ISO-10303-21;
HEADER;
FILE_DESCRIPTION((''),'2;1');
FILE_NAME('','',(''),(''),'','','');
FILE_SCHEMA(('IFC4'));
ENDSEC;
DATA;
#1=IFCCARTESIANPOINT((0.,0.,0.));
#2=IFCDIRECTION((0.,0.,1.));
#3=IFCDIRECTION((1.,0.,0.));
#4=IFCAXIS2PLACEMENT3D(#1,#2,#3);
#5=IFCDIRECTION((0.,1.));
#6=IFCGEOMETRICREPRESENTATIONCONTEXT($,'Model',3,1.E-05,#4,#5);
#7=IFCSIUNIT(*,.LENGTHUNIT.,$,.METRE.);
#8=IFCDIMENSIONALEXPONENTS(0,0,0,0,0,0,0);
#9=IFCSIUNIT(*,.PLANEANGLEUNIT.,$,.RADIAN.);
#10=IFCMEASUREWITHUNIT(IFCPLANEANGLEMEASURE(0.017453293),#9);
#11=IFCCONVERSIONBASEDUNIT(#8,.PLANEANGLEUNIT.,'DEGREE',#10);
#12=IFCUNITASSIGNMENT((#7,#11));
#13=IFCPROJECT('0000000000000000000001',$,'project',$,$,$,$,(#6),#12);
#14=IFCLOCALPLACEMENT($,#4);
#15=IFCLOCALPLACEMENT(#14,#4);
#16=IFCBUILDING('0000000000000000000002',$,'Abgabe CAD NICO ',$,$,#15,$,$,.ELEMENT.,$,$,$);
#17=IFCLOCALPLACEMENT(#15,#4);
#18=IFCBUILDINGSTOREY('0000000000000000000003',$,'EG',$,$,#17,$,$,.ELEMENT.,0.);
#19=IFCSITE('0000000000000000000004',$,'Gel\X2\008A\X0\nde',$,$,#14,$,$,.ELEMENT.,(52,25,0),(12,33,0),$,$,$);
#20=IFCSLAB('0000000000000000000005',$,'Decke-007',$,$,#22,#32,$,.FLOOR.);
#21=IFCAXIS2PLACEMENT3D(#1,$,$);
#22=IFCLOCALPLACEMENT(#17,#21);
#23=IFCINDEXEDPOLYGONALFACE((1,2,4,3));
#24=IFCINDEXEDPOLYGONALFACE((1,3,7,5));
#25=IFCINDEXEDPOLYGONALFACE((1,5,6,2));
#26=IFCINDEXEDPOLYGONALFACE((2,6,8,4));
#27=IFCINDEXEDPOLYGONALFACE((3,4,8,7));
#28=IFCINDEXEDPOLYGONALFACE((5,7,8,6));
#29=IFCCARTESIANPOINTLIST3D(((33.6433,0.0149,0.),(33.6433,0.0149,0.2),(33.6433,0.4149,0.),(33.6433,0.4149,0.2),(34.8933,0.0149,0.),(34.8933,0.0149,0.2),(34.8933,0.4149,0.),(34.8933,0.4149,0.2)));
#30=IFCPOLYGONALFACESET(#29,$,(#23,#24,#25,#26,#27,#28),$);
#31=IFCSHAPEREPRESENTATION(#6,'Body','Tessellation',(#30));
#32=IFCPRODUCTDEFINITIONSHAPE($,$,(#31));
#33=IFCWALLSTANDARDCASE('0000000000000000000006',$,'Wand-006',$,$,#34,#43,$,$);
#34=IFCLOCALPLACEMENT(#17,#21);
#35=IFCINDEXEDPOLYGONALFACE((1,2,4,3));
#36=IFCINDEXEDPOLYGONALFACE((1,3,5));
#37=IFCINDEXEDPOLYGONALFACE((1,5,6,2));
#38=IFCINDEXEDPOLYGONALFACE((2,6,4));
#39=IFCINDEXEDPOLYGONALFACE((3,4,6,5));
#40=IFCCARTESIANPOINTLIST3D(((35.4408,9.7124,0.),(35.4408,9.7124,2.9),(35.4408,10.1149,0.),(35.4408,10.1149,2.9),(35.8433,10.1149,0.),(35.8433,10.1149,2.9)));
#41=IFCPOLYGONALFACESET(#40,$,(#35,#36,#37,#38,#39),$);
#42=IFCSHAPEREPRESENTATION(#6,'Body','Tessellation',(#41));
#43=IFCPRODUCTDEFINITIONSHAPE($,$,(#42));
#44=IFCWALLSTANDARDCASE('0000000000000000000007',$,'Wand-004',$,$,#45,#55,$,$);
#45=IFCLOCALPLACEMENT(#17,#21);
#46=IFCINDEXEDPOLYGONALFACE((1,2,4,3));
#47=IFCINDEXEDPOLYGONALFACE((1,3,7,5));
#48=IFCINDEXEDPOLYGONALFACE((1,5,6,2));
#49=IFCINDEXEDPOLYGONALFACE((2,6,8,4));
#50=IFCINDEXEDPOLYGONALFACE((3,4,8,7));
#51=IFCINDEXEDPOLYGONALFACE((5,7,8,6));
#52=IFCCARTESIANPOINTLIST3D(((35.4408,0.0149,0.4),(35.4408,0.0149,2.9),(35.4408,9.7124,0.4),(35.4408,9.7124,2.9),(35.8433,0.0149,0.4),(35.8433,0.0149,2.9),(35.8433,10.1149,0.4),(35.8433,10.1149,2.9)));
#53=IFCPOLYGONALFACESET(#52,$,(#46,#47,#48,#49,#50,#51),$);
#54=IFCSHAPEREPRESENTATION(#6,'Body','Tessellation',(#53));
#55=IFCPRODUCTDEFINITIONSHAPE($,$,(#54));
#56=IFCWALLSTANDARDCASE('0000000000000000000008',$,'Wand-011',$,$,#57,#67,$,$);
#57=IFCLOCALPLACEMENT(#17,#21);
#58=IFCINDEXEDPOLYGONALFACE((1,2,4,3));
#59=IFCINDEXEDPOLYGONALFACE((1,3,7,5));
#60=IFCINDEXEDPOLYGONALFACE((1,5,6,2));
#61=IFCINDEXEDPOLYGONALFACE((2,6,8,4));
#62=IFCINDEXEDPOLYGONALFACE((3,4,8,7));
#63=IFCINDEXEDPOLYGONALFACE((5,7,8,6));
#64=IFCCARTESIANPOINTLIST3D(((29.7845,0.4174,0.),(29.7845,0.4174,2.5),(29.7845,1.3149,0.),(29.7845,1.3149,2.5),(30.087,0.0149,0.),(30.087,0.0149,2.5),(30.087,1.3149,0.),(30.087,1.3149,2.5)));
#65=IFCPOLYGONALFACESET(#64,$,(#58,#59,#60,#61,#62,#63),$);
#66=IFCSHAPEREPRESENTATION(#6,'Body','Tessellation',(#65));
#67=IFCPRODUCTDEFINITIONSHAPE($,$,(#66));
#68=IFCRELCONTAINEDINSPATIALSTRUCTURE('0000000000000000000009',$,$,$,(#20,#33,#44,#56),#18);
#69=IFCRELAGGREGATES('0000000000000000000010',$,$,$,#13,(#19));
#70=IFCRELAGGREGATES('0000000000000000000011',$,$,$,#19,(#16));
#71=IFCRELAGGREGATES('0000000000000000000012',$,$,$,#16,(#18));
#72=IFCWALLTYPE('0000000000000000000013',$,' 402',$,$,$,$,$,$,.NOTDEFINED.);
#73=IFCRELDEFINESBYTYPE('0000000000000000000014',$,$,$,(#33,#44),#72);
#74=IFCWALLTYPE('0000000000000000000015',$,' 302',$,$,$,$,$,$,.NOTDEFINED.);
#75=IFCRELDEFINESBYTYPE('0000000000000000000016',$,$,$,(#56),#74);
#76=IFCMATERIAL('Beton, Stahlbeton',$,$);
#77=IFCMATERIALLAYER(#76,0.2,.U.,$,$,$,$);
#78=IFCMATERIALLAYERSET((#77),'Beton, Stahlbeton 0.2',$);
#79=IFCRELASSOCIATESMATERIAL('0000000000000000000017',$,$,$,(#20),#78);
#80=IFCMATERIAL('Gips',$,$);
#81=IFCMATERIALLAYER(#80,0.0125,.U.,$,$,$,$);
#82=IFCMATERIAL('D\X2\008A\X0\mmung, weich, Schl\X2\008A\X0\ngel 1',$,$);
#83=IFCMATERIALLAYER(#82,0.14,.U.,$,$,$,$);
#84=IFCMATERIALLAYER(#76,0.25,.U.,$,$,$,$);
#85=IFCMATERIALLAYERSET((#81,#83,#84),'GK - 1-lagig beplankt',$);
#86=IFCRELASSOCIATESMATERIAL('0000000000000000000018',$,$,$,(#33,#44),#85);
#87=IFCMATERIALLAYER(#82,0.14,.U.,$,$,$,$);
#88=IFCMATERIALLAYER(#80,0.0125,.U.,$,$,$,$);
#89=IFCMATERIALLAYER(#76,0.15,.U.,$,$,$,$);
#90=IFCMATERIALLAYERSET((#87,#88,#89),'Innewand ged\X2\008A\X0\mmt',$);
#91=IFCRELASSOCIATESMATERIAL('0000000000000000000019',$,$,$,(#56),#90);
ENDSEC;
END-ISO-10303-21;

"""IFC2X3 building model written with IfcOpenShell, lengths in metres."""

from ifc_helpers import new_model, entity, si_unit, converted_unit, direction, frame, origin_with_axes, place, context, project, spatial, polyline, outline, extrude, material, layer, layer_set, layer_usage, type_object, element, save


model = new_model("IFC2X3")

# Units and contexts
model_context = context("Model", 3, precision=1e-05, world=origin_with_axes(), true_north=direction((0.0, 1.0)))
ifc_project = project(units=[si_unit("LENGTHUNIT", "METRE"), converted_unit("PLANEANGLEUNIT", "DEGREE", entity("IfcPlaneAngleMeasure", 0.017453293), si_unit("PLANEANGLEUNIT", "RADIAN"), dimensions=[0, 0, 0, 0, 0, 0, 0])], contexts=[model_context])

# Site, building, storey
site_placement = place(None, origin_with_axes())
site = spatial("IfcSite", under=ifc_project, at=site_placement, Name="Gel\u008ande", CompositionType="ELEMENT", RefLatitude=(52, 25, 0), RefLongitude=(12, 33, 0))
building_placement = place(site_placement, origin_with_axes())
building = spatial("IfcBuilding", under=site, at=building_placement, Name="Abgabe CAD NICO ", CompositionType="ELEMENT")
storey_placement = place(building_placement, origin_with_axes())
storey = spatial("IfcBuildingStorey", under=building, at=storey_placement, Name="EG", CompositionType="ELEMENT", Elevation=0.0)

# Slab
ifc_material_1 = material(Name="Beton, Stahlbeton")
ifc_layer_1 = layer(ifc_material_1, 0.2, ventilated="UNKNOWN")
ifc_layer_set_1 = layer_set([ifc_layer_1], Name="Beton, Stahlbeton 0.2")
ifc_layer_usage_1 = layer_usage(ifc_layer_set_1, "AXIS3", "NEGATIVE", 0.2)
slab_placement = place(storey_placement, frame((33.6433, 0.0149, 0.0), z_axis=(0.0, 0.0, 1.0), x_axis=(1.0, 0.0, 0.0)))
element("IfcSlab", 1, at=slab_placement, inside=storey, material=ifc_layer_usage_1, Name="Decke-007", PredefinedType="FLOOR", context=model_context, shape_type="SweptSolid", body=[
    extrude(outline(polyline([(0.0, 0.0), (1.25, 0.0), (1.25, 0.4), (0.0, 0.4), (0.0, 0.0)])), origin_with_axes(), (0.0, 0.0, 1.0), 0.2),
])

# Walls
ifc_material_2 = material(Name="Gips")
ifc_layer_2 = layer(ifc_material_2, 0.0125, ventilated="UNKNOWN")
ifc_material_3 = material(Name="D\u008ammung, weich, Schl\u008angel 1")
ifc_layer_3 = layer(ifc_material_3, 0.14, ventilated="UNKNOWN")
ifc_layer_4 = layer(ifc_material_1, 0.25, ventilated="UNKNOWN")
ifc_layer_set_2 = layer_set([ifc_layer_2, ifc_layer_3, ifc_layer_4], Name="GK - 1-lagig beplankt")
ifc_layer_usage_2 = layer_usage(ifc_layer_set_2, "AXIS2", "NEGATIVE", 0.0)
wall_type_1 = type_object("IfcWallType", Name=" 402", PredefinedType="NOTDEFINED")
wall_1_placement = place(storey_placement, frame((35.4408, 10.1149, 0.0), z_axis=(0.0, 0.0, 1.0), x_axis=(1.0, 0.0, 0.0)))
element("IfcWallStandardCase", 2, at=wall_1_placement, inside=storey, type_object=wall_type_1, material=ifc_layer_usage_2, Name="Wand-006", context=model_context, shape_type="SweptSolid", body=[
    extrude(outline(polyline([(0.0, -0.4025), (0.4025, 0.0), (0.0, 0.0), (0.0, -0.4025)])), origin_with_axes(), (0.0, 0.0, 1.0), 2.9),
])
ifc_layer_usage_3 = layer_usage(ifc_layer_set_2, "AXIS2", "NEGATIVE", 0.0)
wall_2_placement = place(storey_placement, frame((35.8433, 10.1149, 0.4), z_axis=(0.0, 0.0, 1.0), x_axis=(0.0, -1.0, 0.0)))
element("IfcWallStandardCase", 3, at=wall_2_placement, inside=storey, type_object=wall_type_1, material=ifc_layer_usage_3, Name="Wand-004", context=model_context, shape_type="SweptSolid", body=[
    extrude(outline(polyline([(0.4025, -0.4025), (10.1, -0.4025), (10.1, 0.0), (0.0, 0.0), (0.4025, -0.4025)])), origin_with_axes(), (0.0, 0.0, 1.0), 2.5),
])
ifc_layer_5 = layer(ifc_material_3, 0.14, ventilated="UNKNOWN")
ifc_layer_6 = layer(ifc_material_2, 0.0125, ventilated="UNKNOWN")
ifc_layer_7 = layer(ifc_material_1, 0.15, ventilated="UNKNOWN")
ifc_layer_set_3 = layer_set([ifc_layer_5, ifc_layer_6, ifc_layer_7], Name="Innewand ged\u008ammt")
ifc_layer_usage_4 = layer_usage(ifc_layer_set_3, "AXIS2", "POSITIVE", 0.0)
wall_type_2 = type_object("IfcWallType", Name=" 302", PredefinedType="NOTDEFINED")
wall_3_placement = place(storey_placement, frame((30.087, 0.0149, 0.0), z_axis=(0.0, 0.0, 1.0), x_axis=(0.0, 1.0, 0.0)))
element("IfcWallStandardCase", 4, at=wall_3_placement, inside=storey, type_object=wall_type_2, material=ifc_layer_usage_4, Name="Wand-011", context=model_context, shape_type="SweptSolid", body=[
    extrude(outline(polyline([(0.0, 0.0), (1.3, 0.0), (1.3, 0.3025), (0.4025, 0.3025), (0.0, 0.0)])), origin_with_axes(), (0.0, 0.0, 1.0), 2.5),
])

save(model, "model.ifc")
